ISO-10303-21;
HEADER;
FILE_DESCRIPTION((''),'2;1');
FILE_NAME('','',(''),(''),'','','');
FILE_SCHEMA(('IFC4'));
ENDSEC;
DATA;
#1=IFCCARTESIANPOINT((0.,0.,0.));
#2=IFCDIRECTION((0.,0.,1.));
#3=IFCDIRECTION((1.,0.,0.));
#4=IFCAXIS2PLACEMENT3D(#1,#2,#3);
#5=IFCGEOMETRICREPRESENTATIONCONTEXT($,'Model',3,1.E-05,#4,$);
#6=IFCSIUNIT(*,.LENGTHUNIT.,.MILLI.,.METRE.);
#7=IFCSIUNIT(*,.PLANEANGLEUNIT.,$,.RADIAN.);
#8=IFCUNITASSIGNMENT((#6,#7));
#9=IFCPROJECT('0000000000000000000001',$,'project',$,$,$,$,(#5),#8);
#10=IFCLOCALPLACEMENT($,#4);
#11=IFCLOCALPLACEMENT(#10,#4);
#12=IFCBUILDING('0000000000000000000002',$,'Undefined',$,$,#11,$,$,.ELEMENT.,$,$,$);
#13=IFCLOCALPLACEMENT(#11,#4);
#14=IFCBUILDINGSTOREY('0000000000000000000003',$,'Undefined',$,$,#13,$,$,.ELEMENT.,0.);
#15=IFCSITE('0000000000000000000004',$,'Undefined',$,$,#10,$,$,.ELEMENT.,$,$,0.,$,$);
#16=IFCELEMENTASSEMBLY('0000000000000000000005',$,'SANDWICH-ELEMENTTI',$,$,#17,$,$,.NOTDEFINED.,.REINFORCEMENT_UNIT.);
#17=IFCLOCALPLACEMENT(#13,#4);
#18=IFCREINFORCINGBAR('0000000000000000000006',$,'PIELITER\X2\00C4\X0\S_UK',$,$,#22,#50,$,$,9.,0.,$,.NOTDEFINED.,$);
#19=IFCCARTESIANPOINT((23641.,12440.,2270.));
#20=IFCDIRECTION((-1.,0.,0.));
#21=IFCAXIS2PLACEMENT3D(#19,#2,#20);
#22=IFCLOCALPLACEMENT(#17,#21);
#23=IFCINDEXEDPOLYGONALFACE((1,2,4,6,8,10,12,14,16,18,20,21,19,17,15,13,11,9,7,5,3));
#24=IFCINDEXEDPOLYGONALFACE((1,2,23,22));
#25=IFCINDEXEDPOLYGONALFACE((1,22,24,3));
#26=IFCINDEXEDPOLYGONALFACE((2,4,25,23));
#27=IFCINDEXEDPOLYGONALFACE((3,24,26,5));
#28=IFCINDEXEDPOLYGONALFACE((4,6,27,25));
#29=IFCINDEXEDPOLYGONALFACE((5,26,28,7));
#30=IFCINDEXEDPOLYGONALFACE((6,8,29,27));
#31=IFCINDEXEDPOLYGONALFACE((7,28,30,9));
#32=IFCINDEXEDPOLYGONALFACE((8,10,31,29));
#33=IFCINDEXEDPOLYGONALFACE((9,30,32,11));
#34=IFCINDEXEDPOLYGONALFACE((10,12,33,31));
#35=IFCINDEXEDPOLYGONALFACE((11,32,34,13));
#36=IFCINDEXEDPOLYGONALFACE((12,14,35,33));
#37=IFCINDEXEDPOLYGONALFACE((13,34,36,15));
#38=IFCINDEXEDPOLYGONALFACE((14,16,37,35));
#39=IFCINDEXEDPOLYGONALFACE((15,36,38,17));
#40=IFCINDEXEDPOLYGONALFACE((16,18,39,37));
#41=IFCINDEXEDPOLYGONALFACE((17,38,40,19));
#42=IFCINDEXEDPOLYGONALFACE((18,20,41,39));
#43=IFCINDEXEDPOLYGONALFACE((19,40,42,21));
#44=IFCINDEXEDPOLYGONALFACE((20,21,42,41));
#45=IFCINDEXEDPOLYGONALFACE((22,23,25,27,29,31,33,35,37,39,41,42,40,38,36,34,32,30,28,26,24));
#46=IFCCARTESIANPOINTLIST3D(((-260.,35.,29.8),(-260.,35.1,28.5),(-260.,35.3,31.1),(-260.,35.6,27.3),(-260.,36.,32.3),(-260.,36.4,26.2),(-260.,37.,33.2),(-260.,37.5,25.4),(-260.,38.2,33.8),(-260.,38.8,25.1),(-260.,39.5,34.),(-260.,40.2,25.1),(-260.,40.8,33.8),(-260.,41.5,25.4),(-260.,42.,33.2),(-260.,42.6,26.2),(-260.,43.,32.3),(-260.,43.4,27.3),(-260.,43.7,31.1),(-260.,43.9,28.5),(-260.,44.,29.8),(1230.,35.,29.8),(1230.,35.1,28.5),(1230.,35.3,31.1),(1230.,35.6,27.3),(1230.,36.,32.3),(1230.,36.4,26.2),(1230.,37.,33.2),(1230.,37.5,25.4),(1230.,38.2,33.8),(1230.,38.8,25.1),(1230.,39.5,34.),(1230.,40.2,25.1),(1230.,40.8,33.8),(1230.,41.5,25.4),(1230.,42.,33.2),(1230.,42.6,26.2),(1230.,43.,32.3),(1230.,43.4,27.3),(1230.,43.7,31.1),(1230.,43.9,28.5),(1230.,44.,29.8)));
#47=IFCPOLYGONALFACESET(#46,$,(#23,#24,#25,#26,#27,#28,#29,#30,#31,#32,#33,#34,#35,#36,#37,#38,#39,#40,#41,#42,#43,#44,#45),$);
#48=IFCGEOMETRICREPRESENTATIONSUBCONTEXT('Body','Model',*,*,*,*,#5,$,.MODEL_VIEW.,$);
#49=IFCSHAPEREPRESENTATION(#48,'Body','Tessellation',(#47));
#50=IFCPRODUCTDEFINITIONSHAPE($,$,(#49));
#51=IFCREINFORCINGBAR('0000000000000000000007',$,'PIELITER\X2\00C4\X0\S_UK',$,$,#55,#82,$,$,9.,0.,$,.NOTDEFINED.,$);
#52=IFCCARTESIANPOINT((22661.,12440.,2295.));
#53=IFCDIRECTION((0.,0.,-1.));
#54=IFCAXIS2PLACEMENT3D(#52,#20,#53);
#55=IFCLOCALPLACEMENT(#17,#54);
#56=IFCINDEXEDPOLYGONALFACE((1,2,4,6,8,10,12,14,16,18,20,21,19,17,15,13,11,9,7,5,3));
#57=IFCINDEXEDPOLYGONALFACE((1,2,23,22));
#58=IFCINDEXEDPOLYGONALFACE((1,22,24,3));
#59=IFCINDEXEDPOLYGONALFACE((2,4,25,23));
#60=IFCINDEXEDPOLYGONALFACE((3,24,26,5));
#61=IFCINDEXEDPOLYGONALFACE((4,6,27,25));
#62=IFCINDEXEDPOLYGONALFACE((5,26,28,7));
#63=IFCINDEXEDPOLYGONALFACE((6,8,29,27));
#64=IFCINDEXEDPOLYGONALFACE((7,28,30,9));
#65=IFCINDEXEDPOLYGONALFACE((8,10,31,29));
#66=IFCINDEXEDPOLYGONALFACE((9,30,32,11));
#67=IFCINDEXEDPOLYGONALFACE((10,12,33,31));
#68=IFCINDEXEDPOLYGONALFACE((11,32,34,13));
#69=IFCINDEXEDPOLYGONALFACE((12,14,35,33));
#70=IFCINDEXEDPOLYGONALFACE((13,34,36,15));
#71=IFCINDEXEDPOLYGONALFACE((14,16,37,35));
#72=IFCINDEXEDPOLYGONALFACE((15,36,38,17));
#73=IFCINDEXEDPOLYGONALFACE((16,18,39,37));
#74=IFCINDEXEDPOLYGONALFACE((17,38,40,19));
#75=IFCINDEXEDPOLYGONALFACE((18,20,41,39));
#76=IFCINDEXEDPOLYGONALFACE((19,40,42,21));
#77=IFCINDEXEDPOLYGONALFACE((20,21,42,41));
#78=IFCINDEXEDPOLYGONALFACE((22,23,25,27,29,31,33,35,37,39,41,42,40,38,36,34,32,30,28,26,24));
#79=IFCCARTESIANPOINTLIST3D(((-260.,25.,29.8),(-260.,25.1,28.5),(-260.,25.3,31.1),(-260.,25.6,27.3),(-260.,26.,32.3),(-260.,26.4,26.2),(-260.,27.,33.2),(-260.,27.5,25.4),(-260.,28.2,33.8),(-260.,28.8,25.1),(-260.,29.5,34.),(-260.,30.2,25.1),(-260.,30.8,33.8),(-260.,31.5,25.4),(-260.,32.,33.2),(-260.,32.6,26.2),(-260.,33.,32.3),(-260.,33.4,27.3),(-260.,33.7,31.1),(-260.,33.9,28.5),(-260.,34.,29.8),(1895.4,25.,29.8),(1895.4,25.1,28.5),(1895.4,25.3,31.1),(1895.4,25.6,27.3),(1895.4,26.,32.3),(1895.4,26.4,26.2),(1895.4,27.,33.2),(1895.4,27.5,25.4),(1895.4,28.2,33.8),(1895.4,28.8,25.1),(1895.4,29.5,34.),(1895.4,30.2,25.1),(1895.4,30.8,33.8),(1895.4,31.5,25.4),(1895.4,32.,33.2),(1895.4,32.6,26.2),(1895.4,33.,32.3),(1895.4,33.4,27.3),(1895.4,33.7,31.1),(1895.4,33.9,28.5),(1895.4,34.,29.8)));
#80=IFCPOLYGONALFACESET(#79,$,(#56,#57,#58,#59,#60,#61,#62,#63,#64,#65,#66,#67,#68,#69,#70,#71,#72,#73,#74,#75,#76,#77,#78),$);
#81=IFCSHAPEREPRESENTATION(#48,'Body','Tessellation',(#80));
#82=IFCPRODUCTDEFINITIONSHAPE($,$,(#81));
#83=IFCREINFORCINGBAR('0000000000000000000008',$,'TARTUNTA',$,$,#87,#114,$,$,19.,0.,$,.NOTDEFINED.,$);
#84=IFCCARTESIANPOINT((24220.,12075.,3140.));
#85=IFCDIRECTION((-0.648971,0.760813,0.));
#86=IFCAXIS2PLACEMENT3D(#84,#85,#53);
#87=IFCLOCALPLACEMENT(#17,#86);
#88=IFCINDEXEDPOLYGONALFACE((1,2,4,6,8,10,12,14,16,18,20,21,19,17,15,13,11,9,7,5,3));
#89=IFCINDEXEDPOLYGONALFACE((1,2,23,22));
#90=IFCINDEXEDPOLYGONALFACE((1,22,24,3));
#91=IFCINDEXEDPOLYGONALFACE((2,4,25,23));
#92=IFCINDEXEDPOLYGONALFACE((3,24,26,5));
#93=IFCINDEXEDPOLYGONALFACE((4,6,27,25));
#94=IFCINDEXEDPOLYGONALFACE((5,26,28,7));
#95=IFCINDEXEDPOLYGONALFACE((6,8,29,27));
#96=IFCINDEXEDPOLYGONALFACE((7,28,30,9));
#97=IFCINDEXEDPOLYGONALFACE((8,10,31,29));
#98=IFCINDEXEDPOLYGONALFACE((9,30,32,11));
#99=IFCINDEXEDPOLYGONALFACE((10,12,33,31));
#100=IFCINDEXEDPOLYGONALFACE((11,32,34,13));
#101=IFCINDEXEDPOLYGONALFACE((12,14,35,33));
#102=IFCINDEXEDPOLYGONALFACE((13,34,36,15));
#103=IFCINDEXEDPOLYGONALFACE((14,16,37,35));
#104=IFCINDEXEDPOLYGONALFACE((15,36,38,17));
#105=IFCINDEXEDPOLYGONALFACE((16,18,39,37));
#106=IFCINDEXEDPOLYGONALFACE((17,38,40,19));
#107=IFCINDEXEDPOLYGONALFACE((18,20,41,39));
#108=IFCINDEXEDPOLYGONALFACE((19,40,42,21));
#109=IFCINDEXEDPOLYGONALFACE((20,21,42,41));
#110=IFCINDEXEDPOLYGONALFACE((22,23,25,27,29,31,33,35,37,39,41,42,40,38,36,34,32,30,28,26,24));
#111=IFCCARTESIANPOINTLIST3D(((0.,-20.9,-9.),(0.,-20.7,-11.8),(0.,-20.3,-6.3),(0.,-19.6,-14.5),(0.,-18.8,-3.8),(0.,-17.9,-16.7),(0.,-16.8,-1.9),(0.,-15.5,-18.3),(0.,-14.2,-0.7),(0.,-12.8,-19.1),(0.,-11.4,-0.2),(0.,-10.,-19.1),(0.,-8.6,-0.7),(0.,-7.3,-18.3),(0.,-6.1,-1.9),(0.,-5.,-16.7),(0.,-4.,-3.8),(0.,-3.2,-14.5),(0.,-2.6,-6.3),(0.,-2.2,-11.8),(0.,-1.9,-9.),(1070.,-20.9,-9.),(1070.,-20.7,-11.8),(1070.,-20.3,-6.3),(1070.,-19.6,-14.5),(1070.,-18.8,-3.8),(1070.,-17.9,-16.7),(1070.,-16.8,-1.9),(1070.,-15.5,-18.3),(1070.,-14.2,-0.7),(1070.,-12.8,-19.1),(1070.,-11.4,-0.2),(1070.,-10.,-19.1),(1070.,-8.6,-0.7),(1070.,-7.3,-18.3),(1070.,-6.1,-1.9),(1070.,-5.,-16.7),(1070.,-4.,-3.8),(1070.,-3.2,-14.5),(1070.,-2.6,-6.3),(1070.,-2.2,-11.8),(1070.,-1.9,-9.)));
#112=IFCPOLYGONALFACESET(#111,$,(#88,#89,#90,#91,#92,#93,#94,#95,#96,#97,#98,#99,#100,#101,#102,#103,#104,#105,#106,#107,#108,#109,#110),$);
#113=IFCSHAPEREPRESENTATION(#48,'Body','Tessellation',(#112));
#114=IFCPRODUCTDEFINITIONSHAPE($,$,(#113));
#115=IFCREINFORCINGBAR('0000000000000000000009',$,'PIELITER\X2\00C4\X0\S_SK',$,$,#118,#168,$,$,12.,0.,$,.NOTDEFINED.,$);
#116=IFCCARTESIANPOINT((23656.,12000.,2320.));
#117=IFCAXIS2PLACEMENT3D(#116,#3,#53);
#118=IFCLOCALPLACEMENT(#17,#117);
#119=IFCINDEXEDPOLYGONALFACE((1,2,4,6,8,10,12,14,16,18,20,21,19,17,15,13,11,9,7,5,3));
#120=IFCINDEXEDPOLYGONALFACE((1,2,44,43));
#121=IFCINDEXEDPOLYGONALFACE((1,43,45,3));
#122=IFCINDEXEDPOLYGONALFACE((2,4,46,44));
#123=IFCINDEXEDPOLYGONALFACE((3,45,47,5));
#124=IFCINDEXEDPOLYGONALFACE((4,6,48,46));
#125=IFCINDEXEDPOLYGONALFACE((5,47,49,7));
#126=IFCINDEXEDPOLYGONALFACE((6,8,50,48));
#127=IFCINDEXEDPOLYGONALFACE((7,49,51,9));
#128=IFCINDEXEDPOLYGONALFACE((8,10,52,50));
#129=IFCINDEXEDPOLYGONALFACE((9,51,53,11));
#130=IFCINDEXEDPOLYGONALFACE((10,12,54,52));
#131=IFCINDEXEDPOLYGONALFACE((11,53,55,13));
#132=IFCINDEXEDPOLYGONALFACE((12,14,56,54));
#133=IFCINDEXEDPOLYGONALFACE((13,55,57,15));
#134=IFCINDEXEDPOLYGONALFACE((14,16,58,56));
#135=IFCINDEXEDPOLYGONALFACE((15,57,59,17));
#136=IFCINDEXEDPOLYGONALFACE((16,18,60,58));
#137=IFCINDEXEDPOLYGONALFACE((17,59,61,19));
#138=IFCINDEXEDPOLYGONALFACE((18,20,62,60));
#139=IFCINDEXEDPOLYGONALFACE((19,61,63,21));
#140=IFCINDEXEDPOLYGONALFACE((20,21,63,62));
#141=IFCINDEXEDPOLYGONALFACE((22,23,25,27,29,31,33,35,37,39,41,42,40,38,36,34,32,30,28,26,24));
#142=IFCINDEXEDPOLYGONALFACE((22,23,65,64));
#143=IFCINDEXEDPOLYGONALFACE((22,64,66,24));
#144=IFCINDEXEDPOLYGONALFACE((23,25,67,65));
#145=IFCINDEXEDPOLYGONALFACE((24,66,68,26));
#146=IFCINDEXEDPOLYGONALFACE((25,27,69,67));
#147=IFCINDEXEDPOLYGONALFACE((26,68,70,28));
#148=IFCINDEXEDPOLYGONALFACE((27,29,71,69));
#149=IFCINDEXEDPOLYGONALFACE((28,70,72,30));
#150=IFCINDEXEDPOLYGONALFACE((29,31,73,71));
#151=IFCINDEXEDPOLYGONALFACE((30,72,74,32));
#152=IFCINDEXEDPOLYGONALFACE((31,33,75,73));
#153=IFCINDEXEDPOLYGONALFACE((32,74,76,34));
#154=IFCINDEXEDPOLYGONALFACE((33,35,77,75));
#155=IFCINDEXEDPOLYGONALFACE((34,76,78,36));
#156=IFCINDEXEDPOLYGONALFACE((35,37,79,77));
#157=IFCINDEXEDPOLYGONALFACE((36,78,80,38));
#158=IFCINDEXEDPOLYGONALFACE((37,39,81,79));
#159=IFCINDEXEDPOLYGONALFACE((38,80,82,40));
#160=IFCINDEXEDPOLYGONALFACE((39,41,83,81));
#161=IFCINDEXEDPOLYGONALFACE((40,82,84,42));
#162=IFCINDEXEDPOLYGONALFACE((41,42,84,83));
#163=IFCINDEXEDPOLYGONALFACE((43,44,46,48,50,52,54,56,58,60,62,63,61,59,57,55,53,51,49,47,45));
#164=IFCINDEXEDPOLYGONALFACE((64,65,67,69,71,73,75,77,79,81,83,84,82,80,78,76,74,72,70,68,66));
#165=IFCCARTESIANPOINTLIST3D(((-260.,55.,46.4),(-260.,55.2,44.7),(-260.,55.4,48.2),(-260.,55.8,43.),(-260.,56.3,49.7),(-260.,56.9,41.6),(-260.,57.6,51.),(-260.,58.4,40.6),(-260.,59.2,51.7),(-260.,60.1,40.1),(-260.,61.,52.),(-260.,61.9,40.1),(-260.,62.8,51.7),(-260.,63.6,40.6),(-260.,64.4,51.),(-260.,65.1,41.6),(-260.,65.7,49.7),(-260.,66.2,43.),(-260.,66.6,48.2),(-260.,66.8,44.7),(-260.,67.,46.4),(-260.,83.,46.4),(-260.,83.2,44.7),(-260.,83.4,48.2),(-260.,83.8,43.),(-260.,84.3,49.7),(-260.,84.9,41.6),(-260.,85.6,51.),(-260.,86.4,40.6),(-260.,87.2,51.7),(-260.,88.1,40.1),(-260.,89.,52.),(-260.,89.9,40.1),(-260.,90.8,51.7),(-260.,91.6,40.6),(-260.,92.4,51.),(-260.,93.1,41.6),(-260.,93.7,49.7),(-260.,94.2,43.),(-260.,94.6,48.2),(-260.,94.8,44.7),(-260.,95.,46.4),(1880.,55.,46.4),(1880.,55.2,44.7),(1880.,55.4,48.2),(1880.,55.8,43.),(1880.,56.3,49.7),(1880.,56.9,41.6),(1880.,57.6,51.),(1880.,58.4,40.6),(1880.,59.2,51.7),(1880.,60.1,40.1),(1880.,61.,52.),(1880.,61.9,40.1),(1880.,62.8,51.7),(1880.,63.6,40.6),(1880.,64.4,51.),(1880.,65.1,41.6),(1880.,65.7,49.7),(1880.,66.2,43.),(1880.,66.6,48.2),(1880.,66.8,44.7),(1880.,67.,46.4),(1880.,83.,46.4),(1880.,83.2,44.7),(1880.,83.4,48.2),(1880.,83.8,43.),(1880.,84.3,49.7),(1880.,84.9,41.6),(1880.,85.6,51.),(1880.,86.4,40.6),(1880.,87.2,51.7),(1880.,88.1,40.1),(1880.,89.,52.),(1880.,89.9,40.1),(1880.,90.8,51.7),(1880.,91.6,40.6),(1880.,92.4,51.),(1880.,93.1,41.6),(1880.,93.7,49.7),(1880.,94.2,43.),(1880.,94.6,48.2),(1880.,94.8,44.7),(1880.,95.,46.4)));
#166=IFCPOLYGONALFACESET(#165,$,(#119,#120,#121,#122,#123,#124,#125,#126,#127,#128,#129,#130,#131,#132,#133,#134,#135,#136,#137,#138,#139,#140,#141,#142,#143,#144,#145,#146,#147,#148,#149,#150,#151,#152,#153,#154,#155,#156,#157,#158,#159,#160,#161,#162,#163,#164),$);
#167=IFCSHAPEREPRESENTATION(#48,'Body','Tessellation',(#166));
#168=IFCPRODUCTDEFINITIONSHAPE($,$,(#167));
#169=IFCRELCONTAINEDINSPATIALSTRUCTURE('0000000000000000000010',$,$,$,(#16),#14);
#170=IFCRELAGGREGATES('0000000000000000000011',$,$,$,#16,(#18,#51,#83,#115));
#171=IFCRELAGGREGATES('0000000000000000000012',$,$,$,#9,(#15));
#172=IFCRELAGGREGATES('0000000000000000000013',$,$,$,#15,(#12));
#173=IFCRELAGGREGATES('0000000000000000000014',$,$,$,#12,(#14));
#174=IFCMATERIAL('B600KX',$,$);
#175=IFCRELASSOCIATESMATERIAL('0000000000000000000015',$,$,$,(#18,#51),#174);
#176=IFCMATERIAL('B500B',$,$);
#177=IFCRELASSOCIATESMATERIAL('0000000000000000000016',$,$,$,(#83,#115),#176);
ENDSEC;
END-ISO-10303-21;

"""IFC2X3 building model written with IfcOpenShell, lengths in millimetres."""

from ifc_helpers import new_model, entity, si_unit, frame, origin_with_axes, place, context, subcontext, project, spatial, source, transform, mapped, material, element, aggregate, save


model = new_model("IFC2X3")

# Units and contexts
model_context = context("Model", 3, precision=1e-05, world=origin_with_axes())
body_context = subcontext(model_context, "Body", "Model", "MODEL_VIEW")
ifc_project = project(units=[si_unit("LENGTHUNIT", "METRE", prefix="MILLI"), si_unit("PLANEANGLEUNIT", "RADIAN")], contexts=[model_context])

# Site, building, storey
site_placement = place(None, origin_with_axes())
site = spatial("IfcSite", under=ifc_project, at=site_placement, Name="Undefined", CompositionType="ELEMENT", RefElevation=0.0)
building_placement = place(site_placement, origin_with_axes())
building = spatial("IfcBuilding", under=site, at=building_placement, Name="Undefined", CompositionType="ELEMENT")
storey_placement = place(building_placement, origin_with_axes())
storey = spatial("IfcBuildingStorey", under=building, at=storey_placement, Name="Undefined", CompositionType="ELEMENT", Elevation=0.0)

# Element assembly
assembly_1_placement = place(storey_placement, origin_with_axes())
assembly_1 = element("IfcElementAssembly", 1, at=assembly_1_placement, inside=storey, Name="SANDWICH-ELEMENTTI", AssemblyPlace="NOTDEFINED", PredefinedType="REINFORCEMENT_UNIT")

# Reinforcing bars
ifc_material_1 = material(Name="B600KX")
shared_shape_1 = source(origin_with_axes(), body_context, "Body", "AdvancedSweptSolid", [
    entity("IfcSweptDiskSolid", entity("IfcTrimmedCurve", entity("IfcLine", entity("IfcCartesianPoint", [0.0, 0.0, 0.0]), entity("IfcVector", entity("IfcDirection", [1.0, 0.0, 0.0]), 1.0)), [entity("IfcParameterValue", 0.0)], [entity("IfcParameterValue", 1490.0)], True, "PARAMETER"), 4.5, None, 0.0, 1490.0),
])
reinforcing_bar_1_placement = place(assembly_1_placement, frame((23641.0, 12440.0, 2270.0), z_axis=(0.0, 0.0, 1.0), x_axis=(-1.0, 0.0, 0.0)))
reinforcing_bar_1 = element("IfcReinforcingBar", 2, at=reinforcing_bar_1_placement, material=ifc_material_1, Name="PIELITERÄS_UK", BarRole="NOTDEFINED", CrossSectionArea=0.0, NominalDiameter=9.0, context=body_context, shape_type="MappedRepresentation", body=[
    mapped(shared_shape_1, transform((-260.0, 39.5, 29.5))),
])
shared_shape_2 = source(origin_with_axes(), body_context, "Body", "AdvancedSweptSolid", [
    entity("IfcSweptDiskSolid", entity("IfcTrimmedCurve", entity("IfcLine", entity("IfcCartesianPoint", [0.0, 0.0, 0.0]), entity("IfcVector", entity("IfcDirection", [1.0, 0.0, 0.0]), 1.0)), [entity("IfcParameterValue", 0.0)], [entity("IfcParameterValue", 2155.4145)], True, "PARAMETER"), 4.5, None, 0.0, 2155.4),
])
reinforcing_bar_2_placement = place(assembly_1_placement, frame((22661.0, 12440.0, 2295.0), z_axis=(-1.0, 0.0, 0.0), x_axis=(0.0, 0.0, -1.0)))
reinforcing_bar_2 = element("IfcReinforcingBar", 3, at=reinforcing_bar_2_placement, material=ifc_material_1, Name="PIELITERÄS_UK", BarRole="NOTDEFINED", CrossSectionArea=0.0, NominalDiameter=9.0, context=body_context, shape_type="MappedRepresentation", body=[
    mapped(shared_shape_2, transform((-260.0, 29.5, 29.5))),
])
ifc_material_2 = material(Name="B500B")
shared_shape_3 = source(origin_with_axes(), body_context, "Body", "AdvancedSweptSolid", [
    entity("IfcSweptDiskSolid", entity("IfcTrimmedCurve", entity("IfcLine", entity("IfcCartesianPoint", [0.0, 0.0, 0.0]), entity("IfcVector", entity("IfcDirection", [1.0, 0.0, 0.0]), 1.0)), [entity("IfcParameterValue", 0.0)], [entity("IfcParameterValue", 1070.0)], True, "PARAMETER"), 9.5, None, 0.0, 1070.0),
])
reinforcing_bar_3_placement = place(assembly_1_placement, frame((24220.0, 12075.0, 3140.0), z_axis=(-0.648971, 0.760813, 0.0), x_axis=(0.0, 0.0, -1.0)))
reinforcing_bar_3 = element("IfcReinforcingBar", 4, at=reinforcing_bar_3_placement, material=ifc_material_2, Name="TARTUNTA", BarRole="NOTDEFINED", CrossSectionArea=0.0, NominalDiameter=19.0, context=body_context, shape_type="MappedRepresentation", body=[
    mapped(shared_shape_3, transform((0.0, -11.4, -9.7))),
])
shared_shape_4 = source(origin_with_axes(), body_context, "Body", "AdvancedSweptSolid", [
    entity("IfcSweptDiskSolid", entity("IfcTrimmedCurve", entity("IfcLine", entity("IfcCartesianPoint", [0.0, 0.0, 0.0]), entity("IfcVector", entity("IfcDirection", [1.0, 0.0, 0.0]), 1.0)), [entity("IfcParameterValue", 0.0)], [entity("IfcParameterValue", 2140.0)], True, "PARAMETER"), 6.0, None, 0.0, 2140.0),
])
shared_shape_5 = source(origin_with_axes(), body_context, "Body", "AdvancedSweptSolid", [
    entity("IfcSweptDiskSolid", entity("IfcTrimmedCurve", entity("IfcLine", entity("IfcCartesianPoint", [0.0, 0.0, 0.0]), entity("IfcVector", entity("IfcDirection", [1.0, 0.0, 0.0]), 1.0)), [entity("IfcParameterValue", 0.0)], [entity("IfcParameterValue", 2140.0)], True, "PARAMETER"), 6.0, None, 0.0, 2140.0),
])
reinforcing_bar_4_placement = place(assembly_1_placement, frame((23656.0, 12000.0, 2320.0), z_axis=(1.0, 0.0, 0.0), x_axis=(0.0, 0.0, -1.0)))
reinforcing_bar_4 = element("IfcReinforcingBar", 5, at=reinforcing_bar_4_placement, material=ifc_material_2, Name="PIELITERÄS_SK", BarRole="NOTDEFINED", CrossSectionArea=0.0, NominalDiameter=12.0, context=body_context, shape_type="MappedRepresentation", body=[
    mapped(shared_shape_4, transform((-260.0, 61.0, 46.0))),
    mapped(shared_shape_5, transform((-260.0, 89.0, 46.0))),
])
aggregate(assembly_1, [reinforcing_bar_1, reinforcing_bar_2, reinforcing_bar_3, reinforcing_bar_4])

save(model, "model.ifc")
